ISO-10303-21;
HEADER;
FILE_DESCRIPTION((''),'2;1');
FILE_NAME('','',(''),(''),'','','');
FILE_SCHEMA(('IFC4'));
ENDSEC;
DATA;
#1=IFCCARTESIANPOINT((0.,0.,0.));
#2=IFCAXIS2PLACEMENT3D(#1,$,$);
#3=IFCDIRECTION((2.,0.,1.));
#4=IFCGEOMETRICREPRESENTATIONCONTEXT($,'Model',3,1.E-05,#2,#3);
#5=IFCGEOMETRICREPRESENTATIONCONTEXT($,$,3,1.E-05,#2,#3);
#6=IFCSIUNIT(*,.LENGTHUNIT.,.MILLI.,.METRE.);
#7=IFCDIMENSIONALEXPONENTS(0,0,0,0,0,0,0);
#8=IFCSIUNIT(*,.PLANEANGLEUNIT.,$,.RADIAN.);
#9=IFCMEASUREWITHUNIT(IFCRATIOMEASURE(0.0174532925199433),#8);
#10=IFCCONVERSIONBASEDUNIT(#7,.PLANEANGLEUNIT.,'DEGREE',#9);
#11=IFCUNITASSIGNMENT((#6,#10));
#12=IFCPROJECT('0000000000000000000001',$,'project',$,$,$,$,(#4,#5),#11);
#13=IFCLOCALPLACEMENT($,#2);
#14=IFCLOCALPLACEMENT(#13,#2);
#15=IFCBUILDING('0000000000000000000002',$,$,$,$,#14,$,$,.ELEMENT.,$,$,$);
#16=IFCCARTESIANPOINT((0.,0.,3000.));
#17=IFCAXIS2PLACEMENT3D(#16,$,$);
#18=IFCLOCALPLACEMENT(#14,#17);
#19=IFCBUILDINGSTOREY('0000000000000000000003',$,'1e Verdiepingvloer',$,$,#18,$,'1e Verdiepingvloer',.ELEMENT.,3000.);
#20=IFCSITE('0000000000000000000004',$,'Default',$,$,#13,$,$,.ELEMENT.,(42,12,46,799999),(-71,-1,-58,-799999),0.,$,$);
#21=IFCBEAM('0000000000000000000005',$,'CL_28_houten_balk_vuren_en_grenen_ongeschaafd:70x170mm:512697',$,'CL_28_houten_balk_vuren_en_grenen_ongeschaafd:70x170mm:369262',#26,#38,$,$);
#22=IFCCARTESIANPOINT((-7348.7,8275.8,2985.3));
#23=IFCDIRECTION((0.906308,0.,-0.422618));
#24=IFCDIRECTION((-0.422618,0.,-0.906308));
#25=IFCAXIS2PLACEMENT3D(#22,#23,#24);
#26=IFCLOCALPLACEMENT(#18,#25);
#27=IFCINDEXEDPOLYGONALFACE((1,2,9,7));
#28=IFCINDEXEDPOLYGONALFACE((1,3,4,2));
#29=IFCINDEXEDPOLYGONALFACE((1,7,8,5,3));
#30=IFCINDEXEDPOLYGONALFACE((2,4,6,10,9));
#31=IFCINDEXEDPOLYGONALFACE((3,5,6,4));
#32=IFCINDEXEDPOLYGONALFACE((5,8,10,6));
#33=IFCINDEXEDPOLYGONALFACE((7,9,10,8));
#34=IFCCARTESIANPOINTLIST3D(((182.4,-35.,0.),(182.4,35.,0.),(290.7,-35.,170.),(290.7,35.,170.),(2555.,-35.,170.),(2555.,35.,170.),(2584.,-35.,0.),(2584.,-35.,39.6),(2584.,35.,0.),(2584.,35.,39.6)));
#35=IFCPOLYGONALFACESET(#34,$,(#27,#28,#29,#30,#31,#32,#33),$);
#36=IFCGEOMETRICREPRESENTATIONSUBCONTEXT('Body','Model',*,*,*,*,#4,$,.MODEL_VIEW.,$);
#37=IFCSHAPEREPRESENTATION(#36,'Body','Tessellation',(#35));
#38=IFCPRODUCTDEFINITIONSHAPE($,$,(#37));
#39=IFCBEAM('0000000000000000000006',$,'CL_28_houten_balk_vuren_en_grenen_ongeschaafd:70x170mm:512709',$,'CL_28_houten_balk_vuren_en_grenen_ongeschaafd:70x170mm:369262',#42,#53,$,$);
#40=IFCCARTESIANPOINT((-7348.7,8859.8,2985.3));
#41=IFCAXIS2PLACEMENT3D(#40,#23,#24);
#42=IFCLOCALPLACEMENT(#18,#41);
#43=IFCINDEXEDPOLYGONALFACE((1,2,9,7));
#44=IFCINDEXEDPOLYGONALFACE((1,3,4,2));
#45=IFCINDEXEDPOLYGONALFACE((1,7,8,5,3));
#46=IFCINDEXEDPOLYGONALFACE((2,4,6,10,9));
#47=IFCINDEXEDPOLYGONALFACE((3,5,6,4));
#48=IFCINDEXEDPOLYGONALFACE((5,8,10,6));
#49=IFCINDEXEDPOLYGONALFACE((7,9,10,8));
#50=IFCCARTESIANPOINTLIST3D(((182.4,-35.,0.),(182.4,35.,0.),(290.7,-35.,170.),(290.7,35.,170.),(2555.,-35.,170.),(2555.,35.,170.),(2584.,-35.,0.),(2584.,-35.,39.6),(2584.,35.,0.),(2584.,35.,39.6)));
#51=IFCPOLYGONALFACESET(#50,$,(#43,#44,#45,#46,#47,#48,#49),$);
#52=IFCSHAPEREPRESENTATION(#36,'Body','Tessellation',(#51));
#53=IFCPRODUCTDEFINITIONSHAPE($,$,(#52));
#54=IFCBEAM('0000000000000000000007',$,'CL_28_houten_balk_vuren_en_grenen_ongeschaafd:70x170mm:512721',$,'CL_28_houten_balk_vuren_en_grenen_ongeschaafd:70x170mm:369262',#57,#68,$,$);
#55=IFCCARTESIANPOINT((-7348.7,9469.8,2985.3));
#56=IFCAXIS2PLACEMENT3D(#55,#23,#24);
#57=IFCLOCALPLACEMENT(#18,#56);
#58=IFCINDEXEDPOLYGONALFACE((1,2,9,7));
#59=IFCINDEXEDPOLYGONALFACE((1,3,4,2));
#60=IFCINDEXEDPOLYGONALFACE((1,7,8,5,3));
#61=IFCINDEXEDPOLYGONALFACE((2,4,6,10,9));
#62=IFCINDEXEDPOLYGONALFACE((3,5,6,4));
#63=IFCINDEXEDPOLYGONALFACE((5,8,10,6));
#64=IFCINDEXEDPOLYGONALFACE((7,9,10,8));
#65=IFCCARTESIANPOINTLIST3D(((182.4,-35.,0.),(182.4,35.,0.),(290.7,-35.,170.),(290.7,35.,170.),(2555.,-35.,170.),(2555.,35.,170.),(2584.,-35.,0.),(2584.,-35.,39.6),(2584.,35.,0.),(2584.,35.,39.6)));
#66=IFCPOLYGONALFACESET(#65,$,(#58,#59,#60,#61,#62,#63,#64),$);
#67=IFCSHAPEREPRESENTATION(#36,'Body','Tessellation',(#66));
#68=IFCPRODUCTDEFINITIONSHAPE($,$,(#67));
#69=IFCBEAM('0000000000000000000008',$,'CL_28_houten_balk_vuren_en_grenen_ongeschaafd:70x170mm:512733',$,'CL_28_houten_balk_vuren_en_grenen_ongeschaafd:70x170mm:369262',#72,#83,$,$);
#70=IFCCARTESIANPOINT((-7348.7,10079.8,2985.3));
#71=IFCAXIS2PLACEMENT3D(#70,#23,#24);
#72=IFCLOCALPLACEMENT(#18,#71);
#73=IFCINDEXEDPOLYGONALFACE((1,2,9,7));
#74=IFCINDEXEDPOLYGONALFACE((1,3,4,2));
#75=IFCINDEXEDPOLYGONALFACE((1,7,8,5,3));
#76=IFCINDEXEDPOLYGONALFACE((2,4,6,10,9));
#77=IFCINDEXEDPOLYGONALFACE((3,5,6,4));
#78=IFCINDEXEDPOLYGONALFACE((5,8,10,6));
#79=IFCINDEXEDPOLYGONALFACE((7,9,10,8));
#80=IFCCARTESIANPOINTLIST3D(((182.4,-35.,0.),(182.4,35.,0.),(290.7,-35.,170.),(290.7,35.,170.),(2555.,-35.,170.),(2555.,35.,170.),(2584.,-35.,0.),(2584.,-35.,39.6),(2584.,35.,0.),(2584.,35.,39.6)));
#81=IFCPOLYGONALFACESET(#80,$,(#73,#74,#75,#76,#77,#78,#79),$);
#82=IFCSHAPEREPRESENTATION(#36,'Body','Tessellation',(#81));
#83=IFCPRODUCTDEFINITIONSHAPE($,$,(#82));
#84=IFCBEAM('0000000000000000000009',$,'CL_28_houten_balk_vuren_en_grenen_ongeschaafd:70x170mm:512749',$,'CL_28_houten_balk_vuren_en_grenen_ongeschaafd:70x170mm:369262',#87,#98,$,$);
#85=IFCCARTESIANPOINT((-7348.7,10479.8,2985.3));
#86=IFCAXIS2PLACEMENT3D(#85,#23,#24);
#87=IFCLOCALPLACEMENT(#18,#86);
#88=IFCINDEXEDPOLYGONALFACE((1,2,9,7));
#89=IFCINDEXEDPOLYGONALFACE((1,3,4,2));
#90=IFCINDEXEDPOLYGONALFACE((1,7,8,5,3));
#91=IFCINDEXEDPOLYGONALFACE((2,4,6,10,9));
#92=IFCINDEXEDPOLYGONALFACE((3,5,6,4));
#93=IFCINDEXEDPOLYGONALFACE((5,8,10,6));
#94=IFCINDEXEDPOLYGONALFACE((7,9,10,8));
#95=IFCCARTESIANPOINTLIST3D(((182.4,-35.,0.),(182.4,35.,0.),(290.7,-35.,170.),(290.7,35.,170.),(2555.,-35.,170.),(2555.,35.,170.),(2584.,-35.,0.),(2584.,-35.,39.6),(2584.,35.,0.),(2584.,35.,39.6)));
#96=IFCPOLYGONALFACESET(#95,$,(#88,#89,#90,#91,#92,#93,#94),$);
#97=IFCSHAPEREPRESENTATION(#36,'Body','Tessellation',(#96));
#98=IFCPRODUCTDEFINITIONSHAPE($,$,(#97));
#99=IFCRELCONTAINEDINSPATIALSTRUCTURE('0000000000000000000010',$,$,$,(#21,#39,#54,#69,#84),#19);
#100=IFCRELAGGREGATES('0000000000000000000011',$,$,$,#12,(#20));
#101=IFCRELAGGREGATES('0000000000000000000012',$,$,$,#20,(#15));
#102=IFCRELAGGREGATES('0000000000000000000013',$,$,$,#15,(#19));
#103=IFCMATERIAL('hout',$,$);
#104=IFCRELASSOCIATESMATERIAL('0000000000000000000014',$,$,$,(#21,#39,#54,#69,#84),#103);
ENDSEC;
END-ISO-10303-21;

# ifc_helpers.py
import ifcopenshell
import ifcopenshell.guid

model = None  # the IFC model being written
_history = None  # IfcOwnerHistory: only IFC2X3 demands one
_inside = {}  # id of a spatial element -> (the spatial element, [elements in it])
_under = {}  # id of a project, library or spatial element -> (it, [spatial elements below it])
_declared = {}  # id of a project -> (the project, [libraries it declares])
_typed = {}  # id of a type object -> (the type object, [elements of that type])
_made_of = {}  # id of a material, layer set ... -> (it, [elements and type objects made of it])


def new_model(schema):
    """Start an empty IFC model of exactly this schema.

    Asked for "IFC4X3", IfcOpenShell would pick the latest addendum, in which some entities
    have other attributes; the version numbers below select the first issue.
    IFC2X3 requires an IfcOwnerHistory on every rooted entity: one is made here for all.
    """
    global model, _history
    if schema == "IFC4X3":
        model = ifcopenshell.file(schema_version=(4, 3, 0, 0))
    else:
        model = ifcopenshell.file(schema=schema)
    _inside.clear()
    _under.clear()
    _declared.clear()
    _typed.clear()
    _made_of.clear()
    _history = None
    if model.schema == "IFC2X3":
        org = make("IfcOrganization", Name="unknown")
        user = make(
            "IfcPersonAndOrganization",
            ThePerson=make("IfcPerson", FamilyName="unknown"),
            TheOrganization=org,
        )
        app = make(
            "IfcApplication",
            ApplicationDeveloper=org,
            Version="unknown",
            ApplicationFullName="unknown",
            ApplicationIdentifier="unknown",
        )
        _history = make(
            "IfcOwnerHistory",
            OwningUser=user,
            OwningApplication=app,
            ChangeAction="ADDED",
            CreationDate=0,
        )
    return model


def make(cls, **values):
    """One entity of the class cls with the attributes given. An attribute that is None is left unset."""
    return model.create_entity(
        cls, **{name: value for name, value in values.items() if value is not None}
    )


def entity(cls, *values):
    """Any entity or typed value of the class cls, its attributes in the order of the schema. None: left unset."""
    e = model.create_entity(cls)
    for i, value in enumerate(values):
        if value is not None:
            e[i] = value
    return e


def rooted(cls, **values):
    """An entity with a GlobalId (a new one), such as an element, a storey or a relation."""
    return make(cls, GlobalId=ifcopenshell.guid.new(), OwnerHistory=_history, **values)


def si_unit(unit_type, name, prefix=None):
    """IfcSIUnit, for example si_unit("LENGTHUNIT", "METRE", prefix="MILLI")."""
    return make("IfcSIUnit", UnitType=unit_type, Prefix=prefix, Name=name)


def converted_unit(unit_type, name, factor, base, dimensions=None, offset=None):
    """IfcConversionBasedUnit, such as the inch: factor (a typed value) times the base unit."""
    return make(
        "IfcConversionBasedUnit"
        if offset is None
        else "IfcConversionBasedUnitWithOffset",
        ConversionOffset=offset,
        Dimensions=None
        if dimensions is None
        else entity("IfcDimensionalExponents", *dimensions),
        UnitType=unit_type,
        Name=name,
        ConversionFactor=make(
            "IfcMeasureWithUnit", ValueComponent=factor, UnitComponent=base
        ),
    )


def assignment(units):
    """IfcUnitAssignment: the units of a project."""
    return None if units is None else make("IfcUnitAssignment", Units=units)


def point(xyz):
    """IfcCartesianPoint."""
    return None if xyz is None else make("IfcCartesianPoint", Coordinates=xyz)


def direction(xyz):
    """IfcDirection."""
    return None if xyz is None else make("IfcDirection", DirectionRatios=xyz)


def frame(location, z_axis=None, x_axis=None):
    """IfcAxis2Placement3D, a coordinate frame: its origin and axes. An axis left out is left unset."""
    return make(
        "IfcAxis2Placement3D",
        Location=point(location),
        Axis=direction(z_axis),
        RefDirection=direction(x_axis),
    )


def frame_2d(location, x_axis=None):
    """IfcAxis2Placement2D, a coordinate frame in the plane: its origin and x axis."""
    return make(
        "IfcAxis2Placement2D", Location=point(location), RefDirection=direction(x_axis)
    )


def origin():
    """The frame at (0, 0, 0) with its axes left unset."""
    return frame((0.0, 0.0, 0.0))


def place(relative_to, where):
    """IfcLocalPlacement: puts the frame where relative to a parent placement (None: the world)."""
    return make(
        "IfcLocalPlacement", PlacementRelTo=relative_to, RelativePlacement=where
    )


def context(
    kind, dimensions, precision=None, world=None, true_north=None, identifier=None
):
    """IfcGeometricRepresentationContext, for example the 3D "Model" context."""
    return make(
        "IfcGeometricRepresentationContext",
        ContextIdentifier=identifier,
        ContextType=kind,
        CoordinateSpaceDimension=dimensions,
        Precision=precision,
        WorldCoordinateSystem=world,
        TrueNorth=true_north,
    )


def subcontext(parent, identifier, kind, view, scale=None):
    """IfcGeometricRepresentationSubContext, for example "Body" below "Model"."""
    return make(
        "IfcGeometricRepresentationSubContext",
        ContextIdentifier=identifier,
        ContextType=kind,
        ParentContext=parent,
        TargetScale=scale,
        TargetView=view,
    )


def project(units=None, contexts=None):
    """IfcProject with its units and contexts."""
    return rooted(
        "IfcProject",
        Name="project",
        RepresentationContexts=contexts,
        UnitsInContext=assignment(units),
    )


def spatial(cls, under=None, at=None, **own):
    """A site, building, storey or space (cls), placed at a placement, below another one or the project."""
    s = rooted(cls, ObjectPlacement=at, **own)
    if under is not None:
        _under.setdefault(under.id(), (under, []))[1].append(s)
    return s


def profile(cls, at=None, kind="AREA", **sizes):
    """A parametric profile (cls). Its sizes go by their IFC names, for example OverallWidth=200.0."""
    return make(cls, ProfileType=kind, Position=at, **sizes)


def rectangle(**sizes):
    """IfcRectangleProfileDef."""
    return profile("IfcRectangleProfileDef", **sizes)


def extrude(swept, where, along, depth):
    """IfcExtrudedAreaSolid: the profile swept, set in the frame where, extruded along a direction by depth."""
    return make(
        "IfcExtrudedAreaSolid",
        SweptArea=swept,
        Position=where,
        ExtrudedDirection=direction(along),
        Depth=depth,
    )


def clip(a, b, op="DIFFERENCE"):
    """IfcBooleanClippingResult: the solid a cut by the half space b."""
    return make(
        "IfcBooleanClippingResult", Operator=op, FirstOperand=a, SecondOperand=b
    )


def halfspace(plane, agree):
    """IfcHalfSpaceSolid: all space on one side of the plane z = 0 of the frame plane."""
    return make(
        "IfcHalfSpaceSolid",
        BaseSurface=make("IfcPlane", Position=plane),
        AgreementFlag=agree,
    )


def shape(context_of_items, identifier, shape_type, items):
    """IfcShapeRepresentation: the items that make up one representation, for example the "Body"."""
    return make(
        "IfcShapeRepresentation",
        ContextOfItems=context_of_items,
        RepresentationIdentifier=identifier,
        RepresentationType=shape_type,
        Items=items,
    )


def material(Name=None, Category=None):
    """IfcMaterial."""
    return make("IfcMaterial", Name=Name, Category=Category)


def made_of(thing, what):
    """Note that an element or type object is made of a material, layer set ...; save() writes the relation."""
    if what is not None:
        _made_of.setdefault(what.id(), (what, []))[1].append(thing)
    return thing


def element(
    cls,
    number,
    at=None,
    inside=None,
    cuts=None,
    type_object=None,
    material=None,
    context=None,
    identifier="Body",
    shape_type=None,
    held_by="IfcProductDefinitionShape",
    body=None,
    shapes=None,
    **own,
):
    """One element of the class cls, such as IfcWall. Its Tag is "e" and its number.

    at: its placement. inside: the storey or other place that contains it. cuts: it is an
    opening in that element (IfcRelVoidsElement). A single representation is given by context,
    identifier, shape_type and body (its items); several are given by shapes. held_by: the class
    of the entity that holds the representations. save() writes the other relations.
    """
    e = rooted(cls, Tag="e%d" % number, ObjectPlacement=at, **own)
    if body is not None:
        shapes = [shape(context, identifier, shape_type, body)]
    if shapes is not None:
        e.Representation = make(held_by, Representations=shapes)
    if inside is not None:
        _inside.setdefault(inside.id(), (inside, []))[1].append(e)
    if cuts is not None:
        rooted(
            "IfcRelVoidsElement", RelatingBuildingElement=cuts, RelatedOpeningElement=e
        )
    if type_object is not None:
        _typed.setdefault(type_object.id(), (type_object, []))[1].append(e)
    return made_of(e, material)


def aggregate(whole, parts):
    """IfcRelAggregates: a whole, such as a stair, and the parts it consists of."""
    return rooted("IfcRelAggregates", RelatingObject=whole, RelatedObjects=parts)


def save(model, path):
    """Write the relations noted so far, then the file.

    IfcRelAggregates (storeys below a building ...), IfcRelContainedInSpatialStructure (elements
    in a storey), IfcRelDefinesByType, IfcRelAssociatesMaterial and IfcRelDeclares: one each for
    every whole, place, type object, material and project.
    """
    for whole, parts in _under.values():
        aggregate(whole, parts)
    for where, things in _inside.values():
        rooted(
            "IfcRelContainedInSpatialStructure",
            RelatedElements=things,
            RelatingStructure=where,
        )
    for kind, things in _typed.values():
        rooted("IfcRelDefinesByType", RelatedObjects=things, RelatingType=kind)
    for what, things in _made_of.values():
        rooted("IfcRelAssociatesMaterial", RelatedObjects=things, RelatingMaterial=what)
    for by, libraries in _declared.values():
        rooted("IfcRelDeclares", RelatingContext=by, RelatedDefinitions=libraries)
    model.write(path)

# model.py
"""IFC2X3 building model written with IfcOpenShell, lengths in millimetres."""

from ifc_helpers import new_model, entity, si_unit, converted_unit, direction, frame, frame_2d, origin, place, context, subcontext, project, spatial, rectangle, extrude, clip, halfspace, material, element, save


model = new_model("IFC2X3")

# Units and contexts
model_context = context("Model", 3, precision=1e-05, world=origin(), true_north=direction((2.0, 0.0, 1.0)))
context_of_model = context(None, 3, precision=1e-05, world=origin(), true_north=direction((2.0, 0.0, 1.0)))
body_context = subcontext(model_context, "Body", "Model", "MODEL_VIEW")
ifc_project = project(units=[si_unit("LENGTHUNIT", "METRE", prefix="MILLI"), converted_unit("PLANEANGLEUNIT", "DEGREE", entity("IfcRatioMeasure", 0.0174532925199433), si_unit("PLANEANGLEUNIT", "RADIAN"), dimensions=[0, 0, 0, 0, 0, 0, 0])], contexts=[model_context, context_of_model])

# Site, building, storey
site_placement = place(None, origin())
site = spatial("IfcSite", under=ifc_project, at=site_placement, Name="Default", CompositionType="ELEMENT", RefLatitude=(42, 12, 46, 799999), RefLongitude=(-71, -1, -58, -799999), RefElevation=0.0)
building_placement = place(site_placement, origin())
building = spatial("IfcBuilding", under=site, at=building_placement, CompositionType="ELEMENT")
storey_placement = place(building_placement, frame((0.0, 0.0, 3000.0)))
storey = spatial("IfcBuildingStorey", under=building, at=storey_placement, Name="1e Verdiepingvloer", LongName="1e Verdiepingvloer", CompositionType="ELEMENT", Elevation=3000.0)

# Beams
ifc_material_1 = material(Name="hout")
beam_1_placement = place(storey_placement, frame((-7348.7, 8275.8, 2985.3), z_axis=(0.906308, 0.0, -0.422618), x_axis=(-0.422618, 0.0, -0.906308)))
element("IfcBeam", 1, at=beam_1_placement, inside=storey, material=ifc_material_1, Name="CL_28_houten_balk_vuren_en_grenen_ongeschaafd:70x170mm:512697", ObjectType="CL_28_houten_balk_vuren_en_grenen_ongeschaafd:70x170mm:369262", context=body_context, shape_type="Clipping", body=[
    clip(clip(extrude(rectangle(XDim=170.0, YDim=70.0, at=frame_2d((0.0, 0.0), x_axis=(0.0, 1.0))), frame((182.4, 0.0, 85.0), z_axis=(1.0, 0.0, 0.0), x_axis=(0.0, 1.0, 0.0)), (0.0, 0.0, 1.0), 2401.5), halfspace(frame((2590.9, -3838.2, 8.5), z_axis=(0.976296, 0.0, 0.21644), x_axis=(-0.21644, 0.0, 0.976296)), False)), halfspace(frame((290.7, -2539.2, 170.0), z_axis=(-0.843391, 0.0, 0.5373), x_axis=(0.5373, 0.0, 0.843391)), False)),
])
beam_2_placement = place(storey_placement, frame((-7348.7, 8859.8, 2985.3), z_axis=(0.906308, 0.0, -0.422618), x_axis=(-0.422618, 0.0, -0.906308)))
element("IfcBeam", 2, at=beam_2_placement, inside=storey, material=ifc_material_1, Name="CL_28_houten_balk_vuren_en_grenen_ongeschaafd:70x170mm:512709", ObjectType="CL_28_houten_balk_vuren_en_grenen_ongeschaafd:70x170mm:369262", context=body_context, shape_type="Clipping", body=[
    clip(clip(extrude(rectangle(XDim=170.0, YDim=70.0, at=frame_2d((0.0, 0.0), x_axis=(0.0, 1.0))), frame((182.4, 0.0, 85.0), z_axis=(1.0, 0.0, 0.0), x_axis=(0.0, 1.0, 0.0)), (0.0, 0.0, 1.0), 2401.5), halfspace(frame((2590.9, -4422.2, 8.5), z_axis=(0.976296, 0.0, 0.21644), x_axis=(-0.21644, 0.0, 0.976296)), False)), halfspace(frame((290.7, -3123.2, 170.0), z_axis=(-0.843391, 0.0, 0.5373), x_axis=(0.5373, 0.0, 0.843391)), False)),
])
beam_3_placement = place(storey_placement, frame((-7348.7, 9469.8, 2985.3), z_axis=(0.906308, 0.0, -0.422618), x_axis=(-0.422618, 0.0, -0.906308)))
element("IfcBeam", 3, at=beam_3_placement, inside=storey, material=ifc_material_1, Name="CL_28_houten_balk_vuren_en_grenen_ongeschaafd:70x170mm:512721", ObjectType="CL_28_houten_balk_vuren_en_grenen_ongeschaafd:70x170mm:369262", context=body_context, shape_type="Clipping", body=[
    clip(clip(extrude(rectangle(XDim=170.0, YDim=70.0, at=frame_2d((0.0, 0.0), x_axis=(0.0, 1.0))), frame((182.4, 0.0, 85.0), z_axis=(1.0, 0.0, 0.0), x_axis=(0.0, 1.0, 0.0)), (0.0, 0.0, 1.0), 2401.5), halfspace(frame((2590.9, -5032.2, 8.5), z_axis=(0.976296, 0.0, 0.21644), x_axis=(-0.21644, 0.0, 0.976296)), False)), halfspace(frame((290.7, -3733.2, 170.0), z_axis=(-0.843391, 0.0, 0.5373), x_axis=(0.5373, 0.0, 0.843391)), False)),
])
beam_4_placement = place(storey_placement, frame((-7348.7, 10079.8, 2985.3), z_axis=(0.906308, 0.0, -0.422618), x_axis=(-0.422618, 0.0, -0.906308)))
element("IfcBeam", 4, at=beam_4_placement, inside=storey, material=ifc_material_1, Name="CL_28_houten_balk_vuren_en_grenen_ongeschaafd:70x170mm:512733", ObjectType="CL_28_houten_balk_vuren_en_grenen_ongeschaafd:70x170mm:369262", context=body_context, shape_type="Clipping", body=[
    clip(clip(extrude(rectangle(XDim=170.0, YDim=70.0, at=frame_2d((0.0, 0.0), x_axis=(0.0, 1.0))), frame((182.4, 0.0, 85.0), z_axis=(1.0, 0.0, 0.0), x_axis=(0.0, 1.0, 0.0)), (0.0, 0.0, 1.0), 2401.5), halfspace(frame((2590.9, -5642.2, 8.5), z_axis=(0.976296, 0.0, 0.21644), x_axis=(-0.21644, 0.0, 0.976296)), False)), halfspace(frame((290.7, -4343.2, 170.0), z_axis=(-0.843391, 0.0, 0.5373), x_axis=(0.5373, 0.0, 0.843391)), False)),
])
beam_5_placement = place(storey_placement, frame((-7348.7, 10479.8, 2985.3), z_axis=(0.906308, 0.0, -0.422618), x_axis=(-0.422618, 0.0, -0.906308)))
element("IfcBeam", 5, at=beam_5_placement, inside=storey, material=ifc_material_1, Name="CL_28_houten_balk_vuren_en_grenen_ongeschaafd:70x170mm:512749", ObjectType="CL_28_houten_balk_vuren_en_grenen_ongeschaafd:70x170mm:369262", context=body_context, shape_type="Clipping", body=[
    clip(clip(extrude(rectangle(XDim=170.0, YDim=70.0, at=frame_2d((0.0, 0.0), x_axis=(0.0, 1.0))), frame((182.4, 0.0, 85.0), z_axis=(1.0, 0.0, 0.0), x_axis=(0.0, 1.0, 0.0)), (0.0, 0.0, 1.0), 2401.5), halfspace(frame((2590.9, -6042.2, 8.5), z_axis=(0.976296, 0.0, 0.21644), x_axis=(-0.21644, 0.0, 0.976296)), False)), halfspace(frame((290.7, -4743.2, 170.0), z_axis=(-0.843391, 0.0, 0.5373), x_axis=(0.5373, 0.0, 0.843391)), False)),
])

save(model, "model.ifc")
